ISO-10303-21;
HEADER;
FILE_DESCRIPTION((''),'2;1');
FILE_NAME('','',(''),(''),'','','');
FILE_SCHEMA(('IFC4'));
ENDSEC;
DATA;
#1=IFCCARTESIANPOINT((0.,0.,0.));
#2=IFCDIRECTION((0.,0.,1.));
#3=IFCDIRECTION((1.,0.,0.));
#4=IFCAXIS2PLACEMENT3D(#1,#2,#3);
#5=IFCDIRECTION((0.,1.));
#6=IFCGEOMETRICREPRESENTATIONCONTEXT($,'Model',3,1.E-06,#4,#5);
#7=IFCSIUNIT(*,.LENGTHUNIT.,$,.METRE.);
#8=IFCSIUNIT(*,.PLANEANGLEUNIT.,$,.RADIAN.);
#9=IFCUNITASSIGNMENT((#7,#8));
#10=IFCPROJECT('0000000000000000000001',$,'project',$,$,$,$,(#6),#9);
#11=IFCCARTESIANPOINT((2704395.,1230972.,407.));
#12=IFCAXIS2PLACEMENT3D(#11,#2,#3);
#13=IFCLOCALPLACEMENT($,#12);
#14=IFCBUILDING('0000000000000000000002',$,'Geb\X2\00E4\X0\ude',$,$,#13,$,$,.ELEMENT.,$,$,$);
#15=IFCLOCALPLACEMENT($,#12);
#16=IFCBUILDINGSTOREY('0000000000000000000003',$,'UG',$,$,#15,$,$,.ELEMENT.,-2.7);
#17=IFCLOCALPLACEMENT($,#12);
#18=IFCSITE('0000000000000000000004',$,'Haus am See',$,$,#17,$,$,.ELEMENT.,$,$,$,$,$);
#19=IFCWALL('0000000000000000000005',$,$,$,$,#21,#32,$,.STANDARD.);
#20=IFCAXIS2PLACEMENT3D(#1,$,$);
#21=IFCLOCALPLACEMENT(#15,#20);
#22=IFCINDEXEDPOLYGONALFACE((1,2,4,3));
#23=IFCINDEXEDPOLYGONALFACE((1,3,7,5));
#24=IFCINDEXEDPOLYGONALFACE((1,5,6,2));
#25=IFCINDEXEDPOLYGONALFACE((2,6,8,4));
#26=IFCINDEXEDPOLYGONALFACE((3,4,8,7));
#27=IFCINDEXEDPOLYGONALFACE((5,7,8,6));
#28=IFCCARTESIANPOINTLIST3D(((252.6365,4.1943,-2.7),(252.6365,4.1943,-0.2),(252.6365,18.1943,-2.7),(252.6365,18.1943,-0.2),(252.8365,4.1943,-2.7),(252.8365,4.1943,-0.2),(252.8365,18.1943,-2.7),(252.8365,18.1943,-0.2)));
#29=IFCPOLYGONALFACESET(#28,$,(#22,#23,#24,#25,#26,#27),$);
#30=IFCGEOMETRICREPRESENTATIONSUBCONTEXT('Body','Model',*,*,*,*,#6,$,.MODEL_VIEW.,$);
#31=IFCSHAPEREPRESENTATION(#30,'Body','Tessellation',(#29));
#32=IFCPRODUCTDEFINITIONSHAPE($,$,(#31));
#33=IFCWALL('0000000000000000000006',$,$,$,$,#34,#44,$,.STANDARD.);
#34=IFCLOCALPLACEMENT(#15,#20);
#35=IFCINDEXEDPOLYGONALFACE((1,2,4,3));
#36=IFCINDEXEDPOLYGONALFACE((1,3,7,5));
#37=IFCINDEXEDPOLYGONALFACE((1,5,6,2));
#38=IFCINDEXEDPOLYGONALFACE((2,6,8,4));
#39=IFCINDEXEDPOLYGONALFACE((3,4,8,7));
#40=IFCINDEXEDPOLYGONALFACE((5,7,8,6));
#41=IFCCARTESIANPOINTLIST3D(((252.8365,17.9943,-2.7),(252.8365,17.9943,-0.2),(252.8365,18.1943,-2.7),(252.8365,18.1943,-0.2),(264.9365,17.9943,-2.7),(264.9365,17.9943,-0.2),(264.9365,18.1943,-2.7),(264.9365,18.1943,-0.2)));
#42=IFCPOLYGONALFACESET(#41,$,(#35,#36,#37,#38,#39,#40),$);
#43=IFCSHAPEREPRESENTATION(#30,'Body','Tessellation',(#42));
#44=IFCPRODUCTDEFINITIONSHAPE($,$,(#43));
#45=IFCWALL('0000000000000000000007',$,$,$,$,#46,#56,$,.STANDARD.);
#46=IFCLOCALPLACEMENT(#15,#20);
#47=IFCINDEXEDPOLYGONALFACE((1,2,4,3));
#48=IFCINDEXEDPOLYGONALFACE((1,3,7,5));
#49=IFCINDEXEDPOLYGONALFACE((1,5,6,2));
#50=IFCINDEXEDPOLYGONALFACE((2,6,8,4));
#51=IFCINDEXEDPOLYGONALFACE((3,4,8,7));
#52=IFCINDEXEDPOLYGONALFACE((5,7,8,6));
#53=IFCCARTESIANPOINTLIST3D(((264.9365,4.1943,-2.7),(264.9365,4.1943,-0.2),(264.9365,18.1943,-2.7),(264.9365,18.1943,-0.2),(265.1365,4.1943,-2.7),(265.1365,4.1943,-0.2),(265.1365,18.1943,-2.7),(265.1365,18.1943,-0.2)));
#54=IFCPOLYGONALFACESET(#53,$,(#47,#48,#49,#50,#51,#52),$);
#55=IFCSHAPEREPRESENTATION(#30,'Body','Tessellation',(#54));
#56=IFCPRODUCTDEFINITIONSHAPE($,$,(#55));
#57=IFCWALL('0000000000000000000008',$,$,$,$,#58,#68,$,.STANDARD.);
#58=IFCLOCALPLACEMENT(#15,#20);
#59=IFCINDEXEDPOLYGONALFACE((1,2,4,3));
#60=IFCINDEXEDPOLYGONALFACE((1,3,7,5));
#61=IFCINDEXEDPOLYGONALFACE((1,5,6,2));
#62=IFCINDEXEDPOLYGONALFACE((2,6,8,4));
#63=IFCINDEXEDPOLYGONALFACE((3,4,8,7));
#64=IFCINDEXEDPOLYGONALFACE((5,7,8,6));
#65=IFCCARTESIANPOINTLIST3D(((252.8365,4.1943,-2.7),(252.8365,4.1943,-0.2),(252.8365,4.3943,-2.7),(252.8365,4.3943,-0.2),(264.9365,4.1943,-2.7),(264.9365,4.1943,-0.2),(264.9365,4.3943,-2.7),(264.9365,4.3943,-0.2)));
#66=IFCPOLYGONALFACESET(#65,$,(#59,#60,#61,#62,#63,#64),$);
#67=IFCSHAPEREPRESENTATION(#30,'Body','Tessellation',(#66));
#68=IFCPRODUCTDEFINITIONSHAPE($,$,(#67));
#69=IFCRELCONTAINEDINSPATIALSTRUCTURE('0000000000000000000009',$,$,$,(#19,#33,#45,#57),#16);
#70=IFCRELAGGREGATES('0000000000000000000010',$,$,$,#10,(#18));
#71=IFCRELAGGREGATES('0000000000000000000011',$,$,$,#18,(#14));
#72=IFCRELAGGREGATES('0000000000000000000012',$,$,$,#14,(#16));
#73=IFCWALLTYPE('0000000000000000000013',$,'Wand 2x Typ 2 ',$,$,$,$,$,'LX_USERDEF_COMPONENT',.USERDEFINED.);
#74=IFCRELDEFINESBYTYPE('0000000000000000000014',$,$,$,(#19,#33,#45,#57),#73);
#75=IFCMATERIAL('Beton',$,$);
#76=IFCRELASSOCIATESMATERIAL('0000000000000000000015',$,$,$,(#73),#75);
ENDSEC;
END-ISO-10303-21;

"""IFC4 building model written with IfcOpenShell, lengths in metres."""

from ifc_helpers import new_model, si_unit, direction, frame, origin_with_axes, place, context, subcontext, project, spatial, polyline, outline, extrude, material, type_object, element, save


model = new_model("IFC4")

# Units and contexts
model_context = context("Model", 3, precision=1e-06, world=origin_with_axes(), true_north=direction((0.0, 1.0)))
body_context = subcontext(model_context, "Body", "Model", "MODEL_VIEW")
ifc_project = project(units=[si_unit("LENGTHUNIT", "METRE"), si_unit("PLANEANGLEUNIT", "RADIAN")], contexts=[model_context])

# Site, building, storey
site_placement = place(None, frame((2704395.0, 1230972.0, 407.0), z_axis=(0.0, 0.0, 1.0), x_axis=(1.0, 0.0, 0.0)))
site = spatial("IfcSite", under=ifc_project, at=site_placement, Name="Haus am See", CompositionType="ELEMENT")
building_placement = place(None, frame((2704395.0, 1230972.0, 407.0), z_axis=(0.0, 0.0, 1.0), x_axis=(1.0, 0.0, 0.0)))
building = spatial("IfcBuilding", under=site, at=building_placement, Name="Gebäude", CompositionType="ELEMENT")
storey_placement = place(None, frame((2704395.0, 1230972.0, 407.0), z_axis=(0.0, 0.0, 1.0), x_axis=(1.0, 0.0, 0.0)))
storey = spatial("IfcBuildingStorey", under=building, at=storey_placement, Name="UG", CompositionType="ELEMENT", Elevation=-2.7)

# Walls
ifc_material_1 = material(Name="Beton")
wall_type = type_object("IfcWallType", Name="Wand 2x Typ 2 ", ElementType="LX_USERDEF_COMPONENT", PredefinedType="USERDEFINED", material=ifc_material_1)
wall_1_placement = place(storey_placement, frame((252.6365, 18.1943, -2.7), z_axis=(0.0, 0.0, 1.0), x_axis=(0.0, -1.0, 0.0)))
element("IfcWall", 1, at=wall_1_placement, inside=storey, type_object=wall_type, PredefinedType="STANDARD", context=body_context, shape_type="SweptSolid", body=[
    extrude(outline(polyline([(0.0, 0.0, 0.0), (14.0, 0.0, 0.0), (14.0, 0.2, 0.0), (0.0, 0.2, 0.0), (0.0, 0.0, 0.0)])), origin_with_axes(), (0.0, 0.0, 1.0), 2.5),
])
wall_2_placement = place(storey_placement, frame((264.9365, 18.1943, -2.7), z_axis=(0.0, 0.0, 1.0), x_axis=(-1.0, 0.0, 0.0)))
element("IfcWall", 2, at=wall_2_placement, inside=storey, type_object=wall_type, PredefinedType="STANDARD", context=body_context, shape_type="SweptSolid", body=[
    extrude(outline(polyline([(0.0, 0.0, 0.0), (12.1, 0.0, 0.0), (12.1, 0.2, 0.0), (0.0, 0.2, 0.0), (0.0, 0.0, 0.0)])), origin_with_axes(), (0.0, 0.0, 1.0), 2.5),
])
wall_3_placement = place(storey_placement, frame((265.1365, 4.1943, -2.7), z_axis=(0.0, 0.0, 1.0), x_axis=(0.0, 1.0, 0.0)))
element("IfcWall", 3, at=wall_3_placement, inside=storey, type_object=wall_type, PredefinedType="STANDARD", context=body_context, shape_type="SweptSolid", body=[
    extrude(outline(polyline([(0.0, 0.0, 0.0), (14.0, 0.0, 0.0), (14.0, 0.2, 0.0), (0.0, 0.2, 0.0), (0.0, 0.0, 0.0)])), origin_with_axes(), (0.0, 0.0, 1.0), 2.5),
])
wall_4_placement = place(storey_placement, frame((252.8365, 4.1943, -2.7), z_axis=(0.0, 0.0, 1.0), x_axis=(1.0, 0.0, 0.0)))
element("IfcWall", 4, at=wall_4_placement, inside=storey, type_object=wall_type, PredefinedType="STANDARD", context=body_context, shape_type="SweptSolid", body=[
    extrude(outline(polyline([(0.0, 0.0, 0.0), (12.1, 0.0, 0.0), (12.1, 0.2, 0.0), (0.0, 0.2, 0.0), (0.0, 0.0, 0.0)])), origin_with_axes(), (0.0, 0.0, 1.0), 2.5),
])

save(model, "model.ifc")
